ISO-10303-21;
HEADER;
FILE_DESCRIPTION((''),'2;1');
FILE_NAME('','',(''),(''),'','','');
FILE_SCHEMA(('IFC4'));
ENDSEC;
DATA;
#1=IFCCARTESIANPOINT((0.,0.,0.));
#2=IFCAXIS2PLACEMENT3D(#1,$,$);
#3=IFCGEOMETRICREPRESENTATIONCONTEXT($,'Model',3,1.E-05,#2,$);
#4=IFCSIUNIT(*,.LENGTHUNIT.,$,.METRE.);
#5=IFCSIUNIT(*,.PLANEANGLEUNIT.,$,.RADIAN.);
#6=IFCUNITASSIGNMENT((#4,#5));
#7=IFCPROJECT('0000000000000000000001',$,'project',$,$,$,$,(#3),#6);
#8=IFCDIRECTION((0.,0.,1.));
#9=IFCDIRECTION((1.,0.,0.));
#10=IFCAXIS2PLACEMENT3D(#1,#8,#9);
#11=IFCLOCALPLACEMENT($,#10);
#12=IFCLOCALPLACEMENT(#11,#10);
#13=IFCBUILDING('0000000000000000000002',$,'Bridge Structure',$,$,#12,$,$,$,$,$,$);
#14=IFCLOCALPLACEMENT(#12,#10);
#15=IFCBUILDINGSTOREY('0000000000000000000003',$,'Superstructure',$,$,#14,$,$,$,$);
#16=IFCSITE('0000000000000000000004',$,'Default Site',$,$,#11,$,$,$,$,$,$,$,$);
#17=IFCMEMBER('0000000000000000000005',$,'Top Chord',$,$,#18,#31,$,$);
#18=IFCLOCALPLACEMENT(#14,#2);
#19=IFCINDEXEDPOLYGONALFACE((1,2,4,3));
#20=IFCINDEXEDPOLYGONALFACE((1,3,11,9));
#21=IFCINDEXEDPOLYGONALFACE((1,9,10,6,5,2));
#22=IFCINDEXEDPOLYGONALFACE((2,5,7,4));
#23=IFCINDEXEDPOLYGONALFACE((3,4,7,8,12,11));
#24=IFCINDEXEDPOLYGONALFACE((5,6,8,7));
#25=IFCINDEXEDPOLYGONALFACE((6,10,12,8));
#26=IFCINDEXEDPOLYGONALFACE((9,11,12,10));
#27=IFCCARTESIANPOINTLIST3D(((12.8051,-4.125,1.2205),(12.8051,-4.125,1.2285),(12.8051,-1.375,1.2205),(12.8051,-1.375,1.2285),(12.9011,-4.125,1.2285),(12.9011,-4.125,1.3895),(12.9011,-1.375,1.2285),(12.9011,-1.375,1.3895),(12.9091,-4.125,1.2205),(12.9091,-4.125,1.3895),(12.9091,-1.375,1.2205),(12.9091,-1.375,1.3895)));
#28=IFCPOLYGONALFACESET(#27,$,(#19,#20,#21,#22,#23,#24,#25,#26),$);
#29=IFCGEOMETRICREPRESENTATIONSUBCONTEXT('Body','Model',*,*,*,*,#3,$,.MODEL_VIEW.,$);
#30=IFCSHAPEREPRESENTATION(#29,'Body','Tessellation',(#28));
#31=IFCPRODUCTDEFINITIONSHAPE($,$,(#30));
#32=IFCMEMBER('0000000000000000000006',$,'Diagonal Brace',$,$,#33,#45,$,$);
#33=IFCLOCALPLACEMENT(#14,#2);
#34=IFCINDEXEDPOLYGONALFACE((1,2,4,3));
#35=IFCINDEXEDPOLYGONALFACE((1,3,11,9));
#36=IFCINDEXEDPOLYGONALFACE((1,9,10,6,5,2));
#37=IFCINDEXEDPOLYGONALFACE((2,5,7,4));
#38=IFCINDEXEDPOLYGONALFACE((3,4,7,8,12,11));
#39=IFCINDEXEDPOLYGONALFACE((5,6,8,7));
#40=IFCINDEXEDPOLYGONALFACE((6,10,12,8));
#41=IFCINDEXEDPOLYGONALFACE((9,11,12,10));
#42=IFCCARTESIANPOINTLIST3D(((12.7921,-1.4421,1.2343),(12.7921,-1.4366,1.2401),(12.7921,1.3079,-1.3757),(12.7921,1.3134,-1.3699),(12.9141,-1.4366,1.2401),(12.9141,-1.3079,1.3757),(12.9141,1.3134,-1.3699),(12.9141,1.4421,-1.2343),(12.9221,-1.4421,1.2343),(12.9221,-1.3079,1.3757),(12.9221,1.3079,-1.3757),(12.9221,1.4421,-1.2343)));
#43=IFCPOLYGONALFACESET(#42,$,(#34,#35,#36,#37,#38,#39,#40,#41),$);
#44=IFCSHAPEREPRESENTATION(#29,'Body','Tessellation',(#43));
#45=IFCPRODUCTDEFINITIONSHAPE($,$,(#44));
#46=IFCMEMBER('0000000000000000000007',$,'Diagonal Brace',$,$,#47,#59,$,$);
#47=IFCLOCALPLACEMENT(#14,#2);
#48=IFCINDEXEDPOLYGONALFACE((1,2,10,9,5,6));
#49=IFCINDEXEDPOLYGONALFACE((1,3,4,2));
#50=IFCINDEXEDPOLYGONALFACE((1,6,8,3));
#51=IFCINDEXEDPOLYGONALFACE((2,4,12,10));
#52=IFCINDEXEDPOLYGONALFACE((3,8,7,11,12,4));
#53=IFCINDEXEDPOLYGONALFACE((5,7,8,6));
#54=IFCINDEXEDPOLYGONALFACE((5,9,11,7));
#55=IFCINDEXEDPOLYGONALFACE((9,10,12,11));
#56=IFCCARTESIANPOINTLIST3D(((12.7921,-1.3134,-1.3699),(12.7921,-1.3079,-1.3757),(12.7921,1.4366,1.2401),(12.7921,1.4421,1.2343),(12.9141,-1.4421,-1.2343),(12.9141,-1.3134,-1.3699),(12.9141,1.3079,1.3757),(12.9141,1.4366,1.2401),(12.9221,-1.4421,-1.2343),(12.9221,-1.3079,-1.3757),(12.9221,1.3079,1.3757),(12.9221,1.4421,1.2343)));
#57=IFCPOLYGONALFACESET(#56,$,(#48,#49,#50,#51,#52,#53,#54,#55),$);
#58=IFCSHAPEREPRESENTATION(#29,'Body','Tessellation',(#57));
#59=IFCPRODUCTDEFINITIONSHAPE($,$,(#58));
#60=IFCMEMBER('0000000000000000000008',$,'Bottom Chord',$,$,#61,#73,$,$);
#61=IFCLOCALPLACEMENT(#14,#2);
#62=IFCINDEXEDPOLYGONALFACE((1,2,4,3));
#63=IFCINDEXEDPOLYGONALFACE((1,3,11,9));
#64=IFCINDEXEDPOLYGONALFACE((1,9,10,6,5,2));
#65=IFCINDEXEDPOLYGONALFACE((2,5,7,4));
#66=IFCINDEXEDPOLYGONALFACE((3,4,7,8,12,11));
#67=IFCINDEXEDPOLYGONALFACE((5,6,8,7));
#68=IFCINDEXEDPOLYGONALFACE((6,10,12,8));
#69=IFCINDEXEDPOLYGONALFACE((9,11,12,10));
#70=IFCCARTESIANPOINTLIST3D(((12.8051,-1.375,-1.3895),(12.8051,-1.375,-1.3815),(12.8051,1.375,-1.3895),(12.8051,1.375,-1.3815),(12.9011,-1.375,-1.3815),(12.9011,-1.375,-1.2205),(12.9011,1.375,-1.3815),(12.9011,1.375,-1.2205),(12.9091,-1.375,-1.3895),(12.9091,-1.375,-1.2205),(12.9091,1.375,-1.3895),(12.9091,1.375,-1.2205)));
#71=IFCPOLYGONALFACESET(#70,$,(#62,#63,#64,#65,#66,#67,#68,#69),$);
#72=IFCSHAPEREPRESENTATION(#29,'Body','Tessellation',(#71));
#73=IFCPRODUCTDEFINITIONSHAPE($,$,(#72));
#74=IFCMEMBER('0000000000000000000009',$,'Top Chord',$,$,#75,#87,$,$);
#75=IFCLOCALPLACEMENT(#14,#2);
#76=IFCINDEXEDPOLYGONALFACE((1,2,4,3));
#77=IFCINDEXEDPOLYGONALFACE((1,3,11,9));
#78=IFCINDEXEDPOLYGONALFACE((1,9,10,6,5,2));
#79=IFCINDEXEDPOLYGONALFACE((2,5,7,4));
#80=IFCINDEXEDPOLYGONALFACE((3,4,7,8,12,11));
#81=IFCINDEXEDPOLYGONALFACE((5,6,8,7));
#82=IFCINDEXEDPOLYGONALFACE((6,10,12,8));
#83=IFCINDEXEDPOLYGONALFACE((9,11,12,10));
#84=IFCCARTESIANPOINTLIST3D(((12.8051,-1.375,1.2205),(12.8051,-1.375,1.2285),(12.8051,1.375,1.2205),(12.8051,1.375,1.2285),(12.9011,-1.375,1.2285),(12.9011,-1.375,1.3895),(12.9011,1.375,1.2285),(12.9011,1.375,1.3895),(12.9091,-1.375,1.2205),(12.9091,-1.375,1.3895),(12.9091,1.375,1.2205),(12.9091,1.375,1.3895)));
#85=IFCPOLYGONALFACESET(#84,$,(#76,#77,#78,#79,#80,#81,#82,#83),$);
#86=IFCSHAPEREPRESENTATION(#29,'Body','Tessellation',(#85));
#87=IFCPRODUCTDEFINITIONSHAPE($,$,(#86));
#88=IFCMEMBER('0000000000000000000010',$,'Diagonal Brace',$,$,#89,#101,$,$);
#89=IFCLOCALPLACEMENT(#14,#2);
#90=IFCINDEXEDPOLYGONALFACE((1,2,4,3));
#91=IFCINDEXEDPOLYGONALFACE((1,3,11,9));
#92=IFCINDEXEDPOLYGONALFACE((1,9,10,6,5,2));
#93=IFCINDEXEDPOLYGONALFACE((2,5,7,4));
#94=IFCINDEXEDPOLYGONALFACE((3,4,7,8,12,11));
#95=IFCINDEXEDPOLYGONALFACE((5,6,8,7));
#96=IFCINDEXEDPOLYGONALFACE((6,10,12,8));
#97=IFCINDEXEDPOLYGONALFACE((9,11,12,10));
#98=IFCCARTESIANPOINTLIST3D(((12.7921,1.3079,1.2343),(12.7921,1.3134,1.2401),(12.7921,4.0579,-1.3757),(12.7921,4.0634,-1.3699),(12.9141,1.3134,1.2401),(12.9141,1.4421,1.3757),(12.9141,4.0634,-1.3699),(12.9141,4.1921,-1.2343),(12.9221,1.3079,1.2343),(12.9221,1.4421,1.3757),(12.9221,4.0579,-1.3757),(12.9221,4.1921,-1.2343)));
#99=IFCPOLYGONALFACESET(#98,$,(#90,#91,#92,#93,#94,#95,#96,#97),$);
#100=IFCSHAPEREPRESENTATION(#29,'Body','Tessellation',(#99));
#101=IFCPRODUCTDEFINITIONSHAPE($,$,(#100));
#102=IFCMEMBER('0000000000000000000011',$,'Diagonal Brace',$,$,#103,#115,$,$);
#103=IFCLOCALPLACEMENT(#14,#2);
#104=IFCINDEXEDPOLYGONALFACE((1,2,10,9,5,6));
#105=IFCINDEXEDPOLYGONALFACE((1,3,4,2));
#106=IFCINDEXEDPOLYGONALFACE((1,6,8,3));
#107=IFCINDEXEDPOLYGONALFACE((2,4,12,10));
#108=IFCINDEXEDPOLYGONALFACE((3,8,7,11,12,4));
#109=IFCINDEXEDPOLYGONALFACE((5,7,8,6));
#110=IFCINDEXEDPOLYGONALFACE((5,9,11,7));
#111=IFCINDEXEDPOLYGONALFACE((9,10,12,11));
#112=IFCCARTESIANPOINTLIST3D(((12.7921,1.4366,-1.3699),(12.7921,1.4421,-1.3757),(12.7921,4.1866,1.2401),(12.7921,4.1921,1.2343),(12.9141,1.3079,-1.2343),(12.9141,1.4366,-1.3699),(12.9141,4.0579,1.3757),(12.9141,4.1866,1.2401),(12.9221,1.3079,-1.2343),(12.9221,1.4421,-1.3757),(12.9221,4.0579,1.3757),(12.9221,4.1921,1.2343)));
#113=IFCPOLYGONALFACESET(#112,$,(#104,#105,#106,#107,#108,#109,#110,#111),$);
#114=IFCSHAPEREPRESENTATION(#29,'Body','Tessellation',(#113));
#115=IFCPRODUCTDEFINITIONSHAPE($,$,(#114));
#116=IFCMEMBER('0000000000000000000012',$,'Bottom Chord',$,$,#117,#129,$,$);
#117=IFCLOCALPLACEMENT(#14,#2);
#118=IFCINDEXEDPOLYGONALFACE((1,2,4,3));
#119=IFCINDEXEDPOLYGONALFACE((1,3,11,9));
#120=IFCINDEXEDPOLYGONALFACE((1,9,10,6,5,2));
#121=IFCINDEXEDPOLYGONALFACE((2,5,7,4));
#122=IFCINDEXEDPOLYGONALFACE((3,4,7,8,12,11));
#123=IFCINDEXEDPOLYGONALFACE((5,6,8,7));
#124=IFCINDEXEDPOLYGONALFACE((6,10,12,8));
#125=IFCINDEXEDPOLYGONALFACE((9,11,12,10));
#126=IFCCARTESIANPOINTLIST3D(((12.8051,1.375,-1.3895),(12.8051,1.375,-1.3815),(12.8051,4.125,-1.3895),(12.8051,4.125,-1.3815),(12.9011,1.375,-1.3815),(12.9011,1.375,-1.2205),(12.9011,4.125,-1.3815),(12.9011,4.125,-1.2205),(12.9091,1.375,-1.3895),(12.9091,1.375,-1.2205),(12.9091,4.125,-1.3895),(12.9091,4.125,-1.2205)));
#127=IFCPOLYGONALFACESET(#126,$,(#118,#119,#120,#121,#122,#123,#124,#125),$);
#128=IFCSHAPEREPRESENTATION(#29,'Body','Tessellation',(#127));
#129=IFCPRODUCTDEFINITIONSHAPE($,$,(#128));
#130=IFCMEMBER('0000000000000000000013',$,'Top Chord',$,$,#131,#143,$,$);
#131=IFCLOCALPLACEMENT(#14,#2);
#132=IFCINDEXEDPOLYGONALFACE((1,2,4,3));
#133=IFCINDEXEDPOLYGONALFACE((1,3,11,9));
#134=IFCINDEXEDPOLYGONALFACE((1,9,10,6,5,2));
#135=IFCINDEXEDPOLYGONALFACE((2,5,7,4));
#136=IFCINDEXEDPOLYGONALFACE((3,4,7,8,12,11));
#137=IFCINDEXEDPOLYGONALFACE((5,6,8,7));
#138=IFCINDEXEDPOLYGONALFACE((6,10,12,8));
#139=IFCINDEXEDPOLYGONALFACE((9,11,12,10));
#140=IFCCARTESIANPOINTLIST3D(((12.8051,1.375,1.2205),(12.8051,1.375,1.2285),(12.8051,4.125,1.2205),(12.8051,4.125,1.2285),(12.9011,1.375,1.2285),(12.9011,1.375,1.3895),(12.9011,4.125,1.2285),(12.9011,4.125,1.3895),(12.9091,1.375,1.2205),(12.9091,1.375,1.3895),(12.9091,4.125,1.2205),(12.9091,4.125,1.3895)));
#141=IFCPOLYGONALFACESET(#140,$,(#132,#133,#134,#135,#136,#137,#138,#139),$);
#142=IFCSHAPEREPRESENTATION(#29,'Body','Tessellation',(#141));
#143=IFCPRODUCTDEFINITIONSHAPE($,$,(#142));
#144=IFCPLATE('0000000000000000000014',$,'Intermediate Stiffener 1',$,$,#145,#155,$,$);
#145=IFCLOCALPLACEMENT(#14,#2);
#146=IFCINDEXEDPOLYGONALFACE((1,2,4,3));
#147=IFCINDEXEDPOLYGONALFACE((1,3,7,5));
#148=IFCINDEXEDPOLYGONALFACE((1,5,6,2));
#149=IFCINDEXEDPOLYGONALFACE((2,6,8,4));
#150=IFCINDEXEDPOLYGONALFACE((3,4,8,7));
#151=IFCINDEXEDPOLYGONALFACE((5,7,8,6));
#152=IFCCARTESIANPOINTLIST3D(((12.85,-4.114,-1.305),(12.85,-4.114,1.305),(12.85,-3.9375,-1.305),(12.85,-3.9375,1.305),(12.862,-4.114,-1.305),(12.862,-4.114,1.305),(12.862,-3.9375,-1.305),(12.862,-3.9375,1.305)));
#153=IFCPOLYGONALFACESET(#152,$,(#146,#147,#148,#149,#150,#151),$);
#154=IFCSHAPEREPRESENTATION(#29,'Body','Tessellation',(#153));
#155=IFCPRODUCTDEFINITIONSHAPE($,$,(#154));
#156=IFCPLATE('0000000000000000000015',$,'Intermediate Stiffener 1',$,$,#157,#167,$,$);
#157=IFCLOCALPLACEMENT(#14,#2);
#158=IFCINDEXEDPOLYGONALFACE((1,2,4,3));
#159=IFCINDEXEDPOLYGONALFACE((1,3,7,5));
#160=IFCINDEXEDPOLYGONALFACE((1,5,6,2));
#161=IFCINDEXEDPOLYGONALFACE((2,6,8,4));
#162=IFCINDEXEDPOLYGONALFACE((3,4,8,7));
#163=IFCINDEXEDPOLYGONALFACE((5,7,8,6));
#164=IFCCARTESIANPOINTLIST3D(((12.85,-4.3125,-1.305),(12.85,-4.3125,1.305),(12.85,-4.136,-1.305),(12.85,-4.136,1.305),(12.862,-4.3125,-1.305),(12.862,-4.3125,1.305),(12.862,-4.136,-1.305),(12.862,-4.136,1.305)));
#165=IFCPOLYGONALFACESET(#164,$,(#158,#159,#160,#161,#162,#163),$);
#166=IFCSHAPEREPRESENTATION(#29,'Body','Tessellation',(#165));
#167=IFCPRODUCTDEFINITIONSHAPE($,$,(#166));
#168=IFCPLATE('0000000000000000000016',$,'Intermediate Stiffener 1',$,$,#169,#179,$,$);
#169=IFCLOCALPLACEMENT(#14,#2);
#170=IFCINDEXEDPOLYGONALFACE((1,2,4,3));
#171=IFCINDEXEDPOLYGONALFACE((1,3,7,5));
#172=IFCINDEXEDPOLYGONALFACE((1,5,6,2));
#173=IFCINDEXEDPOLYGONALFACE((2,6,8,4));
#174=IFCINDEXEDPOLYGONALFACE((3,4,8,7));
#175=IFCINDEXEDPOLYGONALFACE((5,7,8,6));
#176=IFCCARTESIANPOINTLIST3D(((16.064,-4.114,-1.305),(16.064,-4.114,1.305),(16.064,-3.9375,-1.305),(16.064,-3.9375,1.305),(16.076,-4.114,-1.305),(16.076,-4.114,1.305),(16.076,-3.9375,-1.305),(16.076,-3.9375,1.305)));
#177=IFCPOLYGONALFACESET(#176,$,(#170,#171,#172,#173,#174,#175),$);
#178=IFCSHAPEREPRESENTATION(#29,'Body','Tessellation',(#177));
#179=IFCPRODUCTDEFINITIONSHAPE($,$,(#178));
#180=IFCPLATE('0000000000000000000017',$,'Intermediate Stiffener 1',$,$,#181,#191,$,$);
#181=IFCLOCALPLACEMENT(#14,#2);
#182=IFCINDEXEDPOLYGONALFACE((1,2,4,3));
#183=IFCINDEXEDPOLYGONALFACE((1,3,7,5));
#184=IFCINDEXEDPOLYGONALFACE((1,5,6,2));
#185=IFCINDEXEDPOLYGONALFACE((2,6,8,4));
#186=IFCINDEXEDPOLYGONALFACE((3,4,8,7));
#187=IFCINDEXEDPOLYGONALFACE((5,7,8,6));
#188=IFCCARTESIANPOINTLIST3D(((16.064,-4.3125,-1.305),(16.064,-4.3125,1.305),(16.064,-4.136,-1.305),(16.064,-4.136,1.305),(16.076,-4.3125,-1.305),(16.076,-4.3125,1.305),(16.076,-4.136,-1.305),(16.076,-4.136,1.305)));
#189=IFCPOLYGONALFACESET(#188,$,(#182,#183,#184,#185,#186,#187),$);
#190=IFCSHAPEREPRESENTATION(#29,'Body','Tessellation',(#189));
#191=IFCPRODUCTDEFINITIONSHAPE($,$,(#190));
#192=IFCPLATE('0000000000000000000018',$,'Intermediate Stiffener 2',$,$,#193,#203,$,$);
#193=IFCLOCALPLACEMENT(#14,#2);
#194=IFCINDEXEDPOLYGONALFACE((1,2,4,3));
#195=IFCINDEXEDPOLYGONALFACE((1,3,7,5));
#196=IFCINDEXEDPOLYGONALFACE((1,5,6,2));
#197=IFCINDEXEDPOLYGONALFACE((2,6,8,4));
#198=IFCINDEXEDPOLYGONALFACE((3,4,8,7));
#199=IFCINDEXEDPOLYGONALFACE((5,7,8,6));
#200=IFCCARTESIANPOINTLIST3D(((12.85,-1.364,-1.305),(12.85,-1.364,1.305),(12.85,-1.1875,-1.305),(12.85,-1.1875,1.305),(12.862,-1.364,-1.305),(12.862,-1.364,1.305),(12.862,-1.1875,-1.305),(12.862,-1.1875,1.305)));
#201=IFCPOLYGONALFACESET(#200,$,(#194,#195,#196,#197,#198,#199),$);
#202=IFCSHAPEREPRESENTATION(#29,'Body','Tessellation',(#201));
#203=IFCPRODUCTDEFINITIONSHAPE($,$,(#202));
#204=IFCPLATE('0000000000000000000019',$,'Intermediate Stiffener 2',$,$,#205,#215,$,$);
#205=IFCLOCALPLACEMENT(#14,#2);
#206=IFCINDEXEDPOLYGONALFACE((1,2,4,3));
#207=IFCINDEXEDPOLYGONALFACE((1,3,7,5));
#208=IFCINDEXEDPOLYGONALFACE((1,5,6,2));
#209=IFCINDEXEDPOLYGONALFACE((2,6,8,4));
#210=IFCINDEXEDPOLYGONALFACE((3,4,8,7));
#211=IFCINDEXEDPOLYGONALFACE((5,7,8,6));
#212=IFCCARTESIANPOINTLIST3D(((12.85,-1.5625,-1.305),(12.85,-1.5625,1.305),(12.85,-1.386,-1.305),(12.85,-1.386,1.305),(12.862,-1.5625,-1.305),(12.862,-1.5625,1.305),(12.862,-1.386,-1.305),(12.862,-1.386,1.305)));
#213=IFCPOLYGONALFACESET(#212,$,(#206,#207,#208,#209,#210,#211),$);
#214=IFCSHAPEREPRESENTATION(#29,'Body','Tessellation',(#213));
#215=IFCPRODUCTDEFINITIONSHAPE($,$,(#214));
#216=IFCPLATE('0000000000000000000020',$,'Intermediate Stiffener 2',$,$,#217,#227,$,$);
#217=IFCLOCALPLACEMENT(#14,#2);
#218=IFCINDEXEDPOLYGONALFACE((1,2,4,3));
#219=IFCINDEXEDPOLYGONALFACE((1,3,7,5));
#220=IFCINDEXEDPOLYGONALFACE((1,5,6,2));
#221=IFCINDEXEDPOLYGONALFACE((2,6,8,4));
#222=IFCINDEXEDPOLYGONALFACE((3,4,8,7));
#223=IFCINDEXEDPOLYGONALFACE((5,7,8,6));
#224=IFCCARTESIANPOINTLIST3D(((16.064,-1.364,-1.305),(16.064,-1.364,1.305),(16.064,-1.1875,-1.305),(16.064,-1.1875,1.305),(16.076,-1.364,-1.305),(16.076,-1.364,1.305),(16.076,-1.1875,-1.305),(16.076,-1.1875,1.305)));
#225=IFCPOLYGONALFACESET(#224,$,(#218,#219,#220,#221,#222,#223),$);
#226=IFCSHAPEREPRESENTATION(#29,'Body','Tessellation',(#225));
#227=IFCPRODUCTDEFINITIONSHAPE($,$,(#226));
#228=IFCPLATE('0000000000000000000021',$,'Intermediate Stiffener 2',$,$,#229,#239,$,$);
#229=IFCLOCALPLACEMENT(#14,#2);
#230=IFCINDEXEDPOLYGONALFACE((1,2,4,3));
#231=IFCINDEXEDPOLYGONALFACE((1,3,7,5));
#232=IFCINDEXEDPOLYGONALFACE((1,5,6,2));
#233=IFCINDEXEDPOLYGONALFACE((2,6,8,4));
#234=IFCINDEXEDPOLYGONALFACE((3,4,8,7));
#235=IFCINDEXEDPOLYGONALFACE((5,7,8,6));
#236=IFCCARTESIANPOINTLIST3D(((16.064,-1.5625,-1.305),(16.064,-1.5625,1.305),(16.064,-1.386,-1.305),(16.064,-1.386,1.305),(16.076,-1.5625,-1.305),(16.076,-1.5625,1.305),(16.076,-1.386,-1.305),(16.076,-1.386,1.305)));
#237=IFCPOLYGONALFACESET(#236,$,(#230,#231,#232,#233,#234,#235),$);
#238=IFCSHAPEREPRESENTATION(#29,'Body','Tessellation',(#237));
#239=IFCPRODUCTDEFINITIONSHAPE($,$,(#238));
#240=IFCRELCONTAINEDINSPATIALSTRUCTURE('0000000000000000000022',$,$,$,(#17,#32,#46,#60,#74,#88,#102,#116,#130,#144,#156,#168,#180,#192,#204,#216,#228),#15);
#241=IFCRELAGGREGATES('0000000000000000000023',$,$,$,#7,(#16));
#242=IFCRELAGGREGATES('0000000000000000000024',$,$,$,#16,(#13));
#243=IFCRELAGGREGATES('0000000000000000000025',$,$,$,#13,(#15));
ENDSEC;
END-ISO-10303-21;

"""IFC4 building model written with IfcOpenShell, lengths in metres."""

from ifc_helpers import new_model, si_unit, frame, origin, origin_with_axes, origin_2d_with_axis, place, context, subcontext, project, spatial, rectangle, l_section, extrude, element, save


model = new_model("IFC4")

# Units and contexts
model_context = context("Model", 3, precision=1e-05, world=origin())
body_context = subcontext(model_context, "Body", "Model", "MODEL_VIEW")
ifc_project = project(units=[si_unit("LENGTHUNIT", "METRE"), si_unit("PLANEANGLEUNIT", "RADIAN")], contexts=[model_context])

# Site, building, storey
site_placement = place(None, origin_with_axes())
site = spatial("IfcSite", under=ifc_project, at=site_placement, Name="Default Site")
building_placement = place(site_placement, origin_with_axes())
building = spatial("IfcBuilding", under=site, at=building_placement, Name="Bridge Structure")
storey_placement = place(building_placement, origin_with_axes())
storey = spatial("IfcBuildingStorey", under=building, at=storey_placement, Name="Superstructure")

# Members
for number, where, z_axis, x_axis, name in (
    (1, (12.8571, -4.125, 1.305), (0.0, 1.0, 0.0), (-1.0, 0.0, 0.0), "Top Chord"),
):
    element("IfcMember", number, at=place(storey_placement, frame(where, z_axis=z_axis, x_axis=x_axis)), inside=storey, Name=name, context=body_context, shape_type="SweptSolid", body=[
        extrude(l_section(Depth=0.169, Width=0.104, Thickness=0.008, at=origin_2d_with_axis()), origin_with_axes(), (0.0, 0.0, 1.0), 2.75),
    ])
for number, where, z_axis, x_axis, name in (
    (2, (12.8571, -1.375, 1.305), (0.0, 0.725329, -0.688403), (-1.0, 0.0, 0.0), "Diagonal Brace"),
    (3, (12.8571, -1.375, -1.305), (0.0, 0.725329, 0.688403), (-1.0, 0.0, 0.0), "Diagonal Brace"),
):
    element("IfcMember", number, at=place(storey_placement, frame(where, z_axis=z_axis, x_axis=x_axis)), inside=storey, Name=name, context=body_context, shape_type="SweptSolid", body=[
        extrude(l_section(Depth=0.195, Width=0.13, Thickness=0.008, at=origin_2d_with_axis()), origin_with_axes(), (0.0, 0.0, 1.0), 3.7914),
    ])
for number, where, z_axis, x_axis, name in (
    (4, (12.8571, -1.375, -1.305), (0.0, 1.0, 0.0), (-1.0, 0.0, 0.0), "Bottom Chord"),
    (5, (12.8571, -1.375, 1.305), (0.0, 1.0, 0.0), (-1.0, 0.0, 0.0), "Top Chord"),
):
    element("IfcMember", number, at=place(storey_placement, frame(where, z_axis=z_axis, x_axis=x_axis)), inside=storey, Name=name, context=body_context, shape_type="SweptSolid", body=[
        extrude(l_section(Depth=0.169, Width=0.104, Thickness=0.008, at=origin_2d_with_axis()), origin_with_axes(), (0.0, 0.0, 1.0), 2.75),
    ])
for number, where, z_axis, x_axis, name in (
    (6, (12.8571, 1.375, 1.305), (0.0, 0.725329, -0.688403), (-1.0, 0.0, 0.0), "Diagonal Brace"),
    (7, (12.8571, 1.375, -1.305), (0.0, 0.725329, 0.688403), (-1.0, 0.0, 0.0), "Diagonal Brace"),
):
    element("IfcMember", number, at=place(storey_placement, frame(where, z_axis=z_axis, x_axis=x_axis)), inside=storey, Name=name, context=body_context, shape_type="SweptSolid", body=[
        extrude(l_section(Depth=0.195, Width=0.13, Thickness=0.008, at=origin_2d_with_axis()), origin_with_axes(), (0.0, 0.0, 1.0), 3.7914),
    ])
for number, where, z_axis, x_axis, name in (
    (8, (12.8571, 1.375, -1.305), (0.0, 1.0, 0.0), (-1.0, 0.0, 0.0), "Bottom Chord"),
    (9, (12.8571, 1.375, 1.305), (0.0, 1.0, 0.0), (-1.0, 0.0, 0.0), "Top Chord"),
):
    element("IfcMember", number, at=place(storey_placement, frame(where, z_axis=z_axis, x_axis=x_axis)), inside=storey, Name=name, context=body_context, shape_type="SweptSolid", body=[
        extrude(l_section(Depth=0.169, Width=0.104, Thickness=0.008, at=origin_2d_with_axis()), origin_with_axes(), (0.0, 0.0, 1.0), 2.75),
    ])

# Plates
for number, where, z_axis, x_axis, name in (
    (10, (12.856, -4.0258, -1.305), (0.0, 0.0, 1.0), (1.0, 0.0, 0.0), "Intermediate Stiffener 1"),
    (11, (12.856, -4.2243, -1.305), (0.0, 0.0, 1.0), (1.0, 0.0, 0.0), "Intermediate Stiffener 1"),
    (12, (16.07, -4.0258, -1.305), (0.0, 0.0, 1.0), (1.0, 0.0, 0.0), "Intermediate Stiffener 1"),
    (13, (16.07, -4.2243, -1.305), (0.0, 0.0, 1.0), (1.0, 0.0, 0.0), "Intermediate Stiffener 1"),
    (14, (12.856, -1.2757, -1.305), (0.0, 0.0, 1.0), (1.0, 0.0, 0.0), "Intermediate Stiffener 2"),
    (15, (12.856, -1.4743, -1.305), (0.0, 0.0, 1.0), (1.0, 0.0, 0.0), "Intermediate Stiffener 2"),
    (16, (16.07, -1.2757, -1.305), (0.0, 0.0, 1.0), (1.0, 0.0, 0.0), "Intermediate Stiffener 2"),
    (17, (16.07, -1.4743, -1.305), (0.0, 0.0, 1.0), (1.0, 0.0, 0.0), "Intermediate Stiffener 2"),
):
    element("IfcPlate", number, at=place(storey_placement, frame(where, z_axis=z_axis, x_axis=x_axis)), inside=storey, Name=name, context=body_context, shape_type="SweptSolid", body=[
        extrude(rectangle(XDim=0.012, YDim=0.1765, at=origin_2d_with_axis()), origin_with_axes(), (0.0, 0.0, 1.0), 2.61),
    ])

save(model, "model.ifc")
